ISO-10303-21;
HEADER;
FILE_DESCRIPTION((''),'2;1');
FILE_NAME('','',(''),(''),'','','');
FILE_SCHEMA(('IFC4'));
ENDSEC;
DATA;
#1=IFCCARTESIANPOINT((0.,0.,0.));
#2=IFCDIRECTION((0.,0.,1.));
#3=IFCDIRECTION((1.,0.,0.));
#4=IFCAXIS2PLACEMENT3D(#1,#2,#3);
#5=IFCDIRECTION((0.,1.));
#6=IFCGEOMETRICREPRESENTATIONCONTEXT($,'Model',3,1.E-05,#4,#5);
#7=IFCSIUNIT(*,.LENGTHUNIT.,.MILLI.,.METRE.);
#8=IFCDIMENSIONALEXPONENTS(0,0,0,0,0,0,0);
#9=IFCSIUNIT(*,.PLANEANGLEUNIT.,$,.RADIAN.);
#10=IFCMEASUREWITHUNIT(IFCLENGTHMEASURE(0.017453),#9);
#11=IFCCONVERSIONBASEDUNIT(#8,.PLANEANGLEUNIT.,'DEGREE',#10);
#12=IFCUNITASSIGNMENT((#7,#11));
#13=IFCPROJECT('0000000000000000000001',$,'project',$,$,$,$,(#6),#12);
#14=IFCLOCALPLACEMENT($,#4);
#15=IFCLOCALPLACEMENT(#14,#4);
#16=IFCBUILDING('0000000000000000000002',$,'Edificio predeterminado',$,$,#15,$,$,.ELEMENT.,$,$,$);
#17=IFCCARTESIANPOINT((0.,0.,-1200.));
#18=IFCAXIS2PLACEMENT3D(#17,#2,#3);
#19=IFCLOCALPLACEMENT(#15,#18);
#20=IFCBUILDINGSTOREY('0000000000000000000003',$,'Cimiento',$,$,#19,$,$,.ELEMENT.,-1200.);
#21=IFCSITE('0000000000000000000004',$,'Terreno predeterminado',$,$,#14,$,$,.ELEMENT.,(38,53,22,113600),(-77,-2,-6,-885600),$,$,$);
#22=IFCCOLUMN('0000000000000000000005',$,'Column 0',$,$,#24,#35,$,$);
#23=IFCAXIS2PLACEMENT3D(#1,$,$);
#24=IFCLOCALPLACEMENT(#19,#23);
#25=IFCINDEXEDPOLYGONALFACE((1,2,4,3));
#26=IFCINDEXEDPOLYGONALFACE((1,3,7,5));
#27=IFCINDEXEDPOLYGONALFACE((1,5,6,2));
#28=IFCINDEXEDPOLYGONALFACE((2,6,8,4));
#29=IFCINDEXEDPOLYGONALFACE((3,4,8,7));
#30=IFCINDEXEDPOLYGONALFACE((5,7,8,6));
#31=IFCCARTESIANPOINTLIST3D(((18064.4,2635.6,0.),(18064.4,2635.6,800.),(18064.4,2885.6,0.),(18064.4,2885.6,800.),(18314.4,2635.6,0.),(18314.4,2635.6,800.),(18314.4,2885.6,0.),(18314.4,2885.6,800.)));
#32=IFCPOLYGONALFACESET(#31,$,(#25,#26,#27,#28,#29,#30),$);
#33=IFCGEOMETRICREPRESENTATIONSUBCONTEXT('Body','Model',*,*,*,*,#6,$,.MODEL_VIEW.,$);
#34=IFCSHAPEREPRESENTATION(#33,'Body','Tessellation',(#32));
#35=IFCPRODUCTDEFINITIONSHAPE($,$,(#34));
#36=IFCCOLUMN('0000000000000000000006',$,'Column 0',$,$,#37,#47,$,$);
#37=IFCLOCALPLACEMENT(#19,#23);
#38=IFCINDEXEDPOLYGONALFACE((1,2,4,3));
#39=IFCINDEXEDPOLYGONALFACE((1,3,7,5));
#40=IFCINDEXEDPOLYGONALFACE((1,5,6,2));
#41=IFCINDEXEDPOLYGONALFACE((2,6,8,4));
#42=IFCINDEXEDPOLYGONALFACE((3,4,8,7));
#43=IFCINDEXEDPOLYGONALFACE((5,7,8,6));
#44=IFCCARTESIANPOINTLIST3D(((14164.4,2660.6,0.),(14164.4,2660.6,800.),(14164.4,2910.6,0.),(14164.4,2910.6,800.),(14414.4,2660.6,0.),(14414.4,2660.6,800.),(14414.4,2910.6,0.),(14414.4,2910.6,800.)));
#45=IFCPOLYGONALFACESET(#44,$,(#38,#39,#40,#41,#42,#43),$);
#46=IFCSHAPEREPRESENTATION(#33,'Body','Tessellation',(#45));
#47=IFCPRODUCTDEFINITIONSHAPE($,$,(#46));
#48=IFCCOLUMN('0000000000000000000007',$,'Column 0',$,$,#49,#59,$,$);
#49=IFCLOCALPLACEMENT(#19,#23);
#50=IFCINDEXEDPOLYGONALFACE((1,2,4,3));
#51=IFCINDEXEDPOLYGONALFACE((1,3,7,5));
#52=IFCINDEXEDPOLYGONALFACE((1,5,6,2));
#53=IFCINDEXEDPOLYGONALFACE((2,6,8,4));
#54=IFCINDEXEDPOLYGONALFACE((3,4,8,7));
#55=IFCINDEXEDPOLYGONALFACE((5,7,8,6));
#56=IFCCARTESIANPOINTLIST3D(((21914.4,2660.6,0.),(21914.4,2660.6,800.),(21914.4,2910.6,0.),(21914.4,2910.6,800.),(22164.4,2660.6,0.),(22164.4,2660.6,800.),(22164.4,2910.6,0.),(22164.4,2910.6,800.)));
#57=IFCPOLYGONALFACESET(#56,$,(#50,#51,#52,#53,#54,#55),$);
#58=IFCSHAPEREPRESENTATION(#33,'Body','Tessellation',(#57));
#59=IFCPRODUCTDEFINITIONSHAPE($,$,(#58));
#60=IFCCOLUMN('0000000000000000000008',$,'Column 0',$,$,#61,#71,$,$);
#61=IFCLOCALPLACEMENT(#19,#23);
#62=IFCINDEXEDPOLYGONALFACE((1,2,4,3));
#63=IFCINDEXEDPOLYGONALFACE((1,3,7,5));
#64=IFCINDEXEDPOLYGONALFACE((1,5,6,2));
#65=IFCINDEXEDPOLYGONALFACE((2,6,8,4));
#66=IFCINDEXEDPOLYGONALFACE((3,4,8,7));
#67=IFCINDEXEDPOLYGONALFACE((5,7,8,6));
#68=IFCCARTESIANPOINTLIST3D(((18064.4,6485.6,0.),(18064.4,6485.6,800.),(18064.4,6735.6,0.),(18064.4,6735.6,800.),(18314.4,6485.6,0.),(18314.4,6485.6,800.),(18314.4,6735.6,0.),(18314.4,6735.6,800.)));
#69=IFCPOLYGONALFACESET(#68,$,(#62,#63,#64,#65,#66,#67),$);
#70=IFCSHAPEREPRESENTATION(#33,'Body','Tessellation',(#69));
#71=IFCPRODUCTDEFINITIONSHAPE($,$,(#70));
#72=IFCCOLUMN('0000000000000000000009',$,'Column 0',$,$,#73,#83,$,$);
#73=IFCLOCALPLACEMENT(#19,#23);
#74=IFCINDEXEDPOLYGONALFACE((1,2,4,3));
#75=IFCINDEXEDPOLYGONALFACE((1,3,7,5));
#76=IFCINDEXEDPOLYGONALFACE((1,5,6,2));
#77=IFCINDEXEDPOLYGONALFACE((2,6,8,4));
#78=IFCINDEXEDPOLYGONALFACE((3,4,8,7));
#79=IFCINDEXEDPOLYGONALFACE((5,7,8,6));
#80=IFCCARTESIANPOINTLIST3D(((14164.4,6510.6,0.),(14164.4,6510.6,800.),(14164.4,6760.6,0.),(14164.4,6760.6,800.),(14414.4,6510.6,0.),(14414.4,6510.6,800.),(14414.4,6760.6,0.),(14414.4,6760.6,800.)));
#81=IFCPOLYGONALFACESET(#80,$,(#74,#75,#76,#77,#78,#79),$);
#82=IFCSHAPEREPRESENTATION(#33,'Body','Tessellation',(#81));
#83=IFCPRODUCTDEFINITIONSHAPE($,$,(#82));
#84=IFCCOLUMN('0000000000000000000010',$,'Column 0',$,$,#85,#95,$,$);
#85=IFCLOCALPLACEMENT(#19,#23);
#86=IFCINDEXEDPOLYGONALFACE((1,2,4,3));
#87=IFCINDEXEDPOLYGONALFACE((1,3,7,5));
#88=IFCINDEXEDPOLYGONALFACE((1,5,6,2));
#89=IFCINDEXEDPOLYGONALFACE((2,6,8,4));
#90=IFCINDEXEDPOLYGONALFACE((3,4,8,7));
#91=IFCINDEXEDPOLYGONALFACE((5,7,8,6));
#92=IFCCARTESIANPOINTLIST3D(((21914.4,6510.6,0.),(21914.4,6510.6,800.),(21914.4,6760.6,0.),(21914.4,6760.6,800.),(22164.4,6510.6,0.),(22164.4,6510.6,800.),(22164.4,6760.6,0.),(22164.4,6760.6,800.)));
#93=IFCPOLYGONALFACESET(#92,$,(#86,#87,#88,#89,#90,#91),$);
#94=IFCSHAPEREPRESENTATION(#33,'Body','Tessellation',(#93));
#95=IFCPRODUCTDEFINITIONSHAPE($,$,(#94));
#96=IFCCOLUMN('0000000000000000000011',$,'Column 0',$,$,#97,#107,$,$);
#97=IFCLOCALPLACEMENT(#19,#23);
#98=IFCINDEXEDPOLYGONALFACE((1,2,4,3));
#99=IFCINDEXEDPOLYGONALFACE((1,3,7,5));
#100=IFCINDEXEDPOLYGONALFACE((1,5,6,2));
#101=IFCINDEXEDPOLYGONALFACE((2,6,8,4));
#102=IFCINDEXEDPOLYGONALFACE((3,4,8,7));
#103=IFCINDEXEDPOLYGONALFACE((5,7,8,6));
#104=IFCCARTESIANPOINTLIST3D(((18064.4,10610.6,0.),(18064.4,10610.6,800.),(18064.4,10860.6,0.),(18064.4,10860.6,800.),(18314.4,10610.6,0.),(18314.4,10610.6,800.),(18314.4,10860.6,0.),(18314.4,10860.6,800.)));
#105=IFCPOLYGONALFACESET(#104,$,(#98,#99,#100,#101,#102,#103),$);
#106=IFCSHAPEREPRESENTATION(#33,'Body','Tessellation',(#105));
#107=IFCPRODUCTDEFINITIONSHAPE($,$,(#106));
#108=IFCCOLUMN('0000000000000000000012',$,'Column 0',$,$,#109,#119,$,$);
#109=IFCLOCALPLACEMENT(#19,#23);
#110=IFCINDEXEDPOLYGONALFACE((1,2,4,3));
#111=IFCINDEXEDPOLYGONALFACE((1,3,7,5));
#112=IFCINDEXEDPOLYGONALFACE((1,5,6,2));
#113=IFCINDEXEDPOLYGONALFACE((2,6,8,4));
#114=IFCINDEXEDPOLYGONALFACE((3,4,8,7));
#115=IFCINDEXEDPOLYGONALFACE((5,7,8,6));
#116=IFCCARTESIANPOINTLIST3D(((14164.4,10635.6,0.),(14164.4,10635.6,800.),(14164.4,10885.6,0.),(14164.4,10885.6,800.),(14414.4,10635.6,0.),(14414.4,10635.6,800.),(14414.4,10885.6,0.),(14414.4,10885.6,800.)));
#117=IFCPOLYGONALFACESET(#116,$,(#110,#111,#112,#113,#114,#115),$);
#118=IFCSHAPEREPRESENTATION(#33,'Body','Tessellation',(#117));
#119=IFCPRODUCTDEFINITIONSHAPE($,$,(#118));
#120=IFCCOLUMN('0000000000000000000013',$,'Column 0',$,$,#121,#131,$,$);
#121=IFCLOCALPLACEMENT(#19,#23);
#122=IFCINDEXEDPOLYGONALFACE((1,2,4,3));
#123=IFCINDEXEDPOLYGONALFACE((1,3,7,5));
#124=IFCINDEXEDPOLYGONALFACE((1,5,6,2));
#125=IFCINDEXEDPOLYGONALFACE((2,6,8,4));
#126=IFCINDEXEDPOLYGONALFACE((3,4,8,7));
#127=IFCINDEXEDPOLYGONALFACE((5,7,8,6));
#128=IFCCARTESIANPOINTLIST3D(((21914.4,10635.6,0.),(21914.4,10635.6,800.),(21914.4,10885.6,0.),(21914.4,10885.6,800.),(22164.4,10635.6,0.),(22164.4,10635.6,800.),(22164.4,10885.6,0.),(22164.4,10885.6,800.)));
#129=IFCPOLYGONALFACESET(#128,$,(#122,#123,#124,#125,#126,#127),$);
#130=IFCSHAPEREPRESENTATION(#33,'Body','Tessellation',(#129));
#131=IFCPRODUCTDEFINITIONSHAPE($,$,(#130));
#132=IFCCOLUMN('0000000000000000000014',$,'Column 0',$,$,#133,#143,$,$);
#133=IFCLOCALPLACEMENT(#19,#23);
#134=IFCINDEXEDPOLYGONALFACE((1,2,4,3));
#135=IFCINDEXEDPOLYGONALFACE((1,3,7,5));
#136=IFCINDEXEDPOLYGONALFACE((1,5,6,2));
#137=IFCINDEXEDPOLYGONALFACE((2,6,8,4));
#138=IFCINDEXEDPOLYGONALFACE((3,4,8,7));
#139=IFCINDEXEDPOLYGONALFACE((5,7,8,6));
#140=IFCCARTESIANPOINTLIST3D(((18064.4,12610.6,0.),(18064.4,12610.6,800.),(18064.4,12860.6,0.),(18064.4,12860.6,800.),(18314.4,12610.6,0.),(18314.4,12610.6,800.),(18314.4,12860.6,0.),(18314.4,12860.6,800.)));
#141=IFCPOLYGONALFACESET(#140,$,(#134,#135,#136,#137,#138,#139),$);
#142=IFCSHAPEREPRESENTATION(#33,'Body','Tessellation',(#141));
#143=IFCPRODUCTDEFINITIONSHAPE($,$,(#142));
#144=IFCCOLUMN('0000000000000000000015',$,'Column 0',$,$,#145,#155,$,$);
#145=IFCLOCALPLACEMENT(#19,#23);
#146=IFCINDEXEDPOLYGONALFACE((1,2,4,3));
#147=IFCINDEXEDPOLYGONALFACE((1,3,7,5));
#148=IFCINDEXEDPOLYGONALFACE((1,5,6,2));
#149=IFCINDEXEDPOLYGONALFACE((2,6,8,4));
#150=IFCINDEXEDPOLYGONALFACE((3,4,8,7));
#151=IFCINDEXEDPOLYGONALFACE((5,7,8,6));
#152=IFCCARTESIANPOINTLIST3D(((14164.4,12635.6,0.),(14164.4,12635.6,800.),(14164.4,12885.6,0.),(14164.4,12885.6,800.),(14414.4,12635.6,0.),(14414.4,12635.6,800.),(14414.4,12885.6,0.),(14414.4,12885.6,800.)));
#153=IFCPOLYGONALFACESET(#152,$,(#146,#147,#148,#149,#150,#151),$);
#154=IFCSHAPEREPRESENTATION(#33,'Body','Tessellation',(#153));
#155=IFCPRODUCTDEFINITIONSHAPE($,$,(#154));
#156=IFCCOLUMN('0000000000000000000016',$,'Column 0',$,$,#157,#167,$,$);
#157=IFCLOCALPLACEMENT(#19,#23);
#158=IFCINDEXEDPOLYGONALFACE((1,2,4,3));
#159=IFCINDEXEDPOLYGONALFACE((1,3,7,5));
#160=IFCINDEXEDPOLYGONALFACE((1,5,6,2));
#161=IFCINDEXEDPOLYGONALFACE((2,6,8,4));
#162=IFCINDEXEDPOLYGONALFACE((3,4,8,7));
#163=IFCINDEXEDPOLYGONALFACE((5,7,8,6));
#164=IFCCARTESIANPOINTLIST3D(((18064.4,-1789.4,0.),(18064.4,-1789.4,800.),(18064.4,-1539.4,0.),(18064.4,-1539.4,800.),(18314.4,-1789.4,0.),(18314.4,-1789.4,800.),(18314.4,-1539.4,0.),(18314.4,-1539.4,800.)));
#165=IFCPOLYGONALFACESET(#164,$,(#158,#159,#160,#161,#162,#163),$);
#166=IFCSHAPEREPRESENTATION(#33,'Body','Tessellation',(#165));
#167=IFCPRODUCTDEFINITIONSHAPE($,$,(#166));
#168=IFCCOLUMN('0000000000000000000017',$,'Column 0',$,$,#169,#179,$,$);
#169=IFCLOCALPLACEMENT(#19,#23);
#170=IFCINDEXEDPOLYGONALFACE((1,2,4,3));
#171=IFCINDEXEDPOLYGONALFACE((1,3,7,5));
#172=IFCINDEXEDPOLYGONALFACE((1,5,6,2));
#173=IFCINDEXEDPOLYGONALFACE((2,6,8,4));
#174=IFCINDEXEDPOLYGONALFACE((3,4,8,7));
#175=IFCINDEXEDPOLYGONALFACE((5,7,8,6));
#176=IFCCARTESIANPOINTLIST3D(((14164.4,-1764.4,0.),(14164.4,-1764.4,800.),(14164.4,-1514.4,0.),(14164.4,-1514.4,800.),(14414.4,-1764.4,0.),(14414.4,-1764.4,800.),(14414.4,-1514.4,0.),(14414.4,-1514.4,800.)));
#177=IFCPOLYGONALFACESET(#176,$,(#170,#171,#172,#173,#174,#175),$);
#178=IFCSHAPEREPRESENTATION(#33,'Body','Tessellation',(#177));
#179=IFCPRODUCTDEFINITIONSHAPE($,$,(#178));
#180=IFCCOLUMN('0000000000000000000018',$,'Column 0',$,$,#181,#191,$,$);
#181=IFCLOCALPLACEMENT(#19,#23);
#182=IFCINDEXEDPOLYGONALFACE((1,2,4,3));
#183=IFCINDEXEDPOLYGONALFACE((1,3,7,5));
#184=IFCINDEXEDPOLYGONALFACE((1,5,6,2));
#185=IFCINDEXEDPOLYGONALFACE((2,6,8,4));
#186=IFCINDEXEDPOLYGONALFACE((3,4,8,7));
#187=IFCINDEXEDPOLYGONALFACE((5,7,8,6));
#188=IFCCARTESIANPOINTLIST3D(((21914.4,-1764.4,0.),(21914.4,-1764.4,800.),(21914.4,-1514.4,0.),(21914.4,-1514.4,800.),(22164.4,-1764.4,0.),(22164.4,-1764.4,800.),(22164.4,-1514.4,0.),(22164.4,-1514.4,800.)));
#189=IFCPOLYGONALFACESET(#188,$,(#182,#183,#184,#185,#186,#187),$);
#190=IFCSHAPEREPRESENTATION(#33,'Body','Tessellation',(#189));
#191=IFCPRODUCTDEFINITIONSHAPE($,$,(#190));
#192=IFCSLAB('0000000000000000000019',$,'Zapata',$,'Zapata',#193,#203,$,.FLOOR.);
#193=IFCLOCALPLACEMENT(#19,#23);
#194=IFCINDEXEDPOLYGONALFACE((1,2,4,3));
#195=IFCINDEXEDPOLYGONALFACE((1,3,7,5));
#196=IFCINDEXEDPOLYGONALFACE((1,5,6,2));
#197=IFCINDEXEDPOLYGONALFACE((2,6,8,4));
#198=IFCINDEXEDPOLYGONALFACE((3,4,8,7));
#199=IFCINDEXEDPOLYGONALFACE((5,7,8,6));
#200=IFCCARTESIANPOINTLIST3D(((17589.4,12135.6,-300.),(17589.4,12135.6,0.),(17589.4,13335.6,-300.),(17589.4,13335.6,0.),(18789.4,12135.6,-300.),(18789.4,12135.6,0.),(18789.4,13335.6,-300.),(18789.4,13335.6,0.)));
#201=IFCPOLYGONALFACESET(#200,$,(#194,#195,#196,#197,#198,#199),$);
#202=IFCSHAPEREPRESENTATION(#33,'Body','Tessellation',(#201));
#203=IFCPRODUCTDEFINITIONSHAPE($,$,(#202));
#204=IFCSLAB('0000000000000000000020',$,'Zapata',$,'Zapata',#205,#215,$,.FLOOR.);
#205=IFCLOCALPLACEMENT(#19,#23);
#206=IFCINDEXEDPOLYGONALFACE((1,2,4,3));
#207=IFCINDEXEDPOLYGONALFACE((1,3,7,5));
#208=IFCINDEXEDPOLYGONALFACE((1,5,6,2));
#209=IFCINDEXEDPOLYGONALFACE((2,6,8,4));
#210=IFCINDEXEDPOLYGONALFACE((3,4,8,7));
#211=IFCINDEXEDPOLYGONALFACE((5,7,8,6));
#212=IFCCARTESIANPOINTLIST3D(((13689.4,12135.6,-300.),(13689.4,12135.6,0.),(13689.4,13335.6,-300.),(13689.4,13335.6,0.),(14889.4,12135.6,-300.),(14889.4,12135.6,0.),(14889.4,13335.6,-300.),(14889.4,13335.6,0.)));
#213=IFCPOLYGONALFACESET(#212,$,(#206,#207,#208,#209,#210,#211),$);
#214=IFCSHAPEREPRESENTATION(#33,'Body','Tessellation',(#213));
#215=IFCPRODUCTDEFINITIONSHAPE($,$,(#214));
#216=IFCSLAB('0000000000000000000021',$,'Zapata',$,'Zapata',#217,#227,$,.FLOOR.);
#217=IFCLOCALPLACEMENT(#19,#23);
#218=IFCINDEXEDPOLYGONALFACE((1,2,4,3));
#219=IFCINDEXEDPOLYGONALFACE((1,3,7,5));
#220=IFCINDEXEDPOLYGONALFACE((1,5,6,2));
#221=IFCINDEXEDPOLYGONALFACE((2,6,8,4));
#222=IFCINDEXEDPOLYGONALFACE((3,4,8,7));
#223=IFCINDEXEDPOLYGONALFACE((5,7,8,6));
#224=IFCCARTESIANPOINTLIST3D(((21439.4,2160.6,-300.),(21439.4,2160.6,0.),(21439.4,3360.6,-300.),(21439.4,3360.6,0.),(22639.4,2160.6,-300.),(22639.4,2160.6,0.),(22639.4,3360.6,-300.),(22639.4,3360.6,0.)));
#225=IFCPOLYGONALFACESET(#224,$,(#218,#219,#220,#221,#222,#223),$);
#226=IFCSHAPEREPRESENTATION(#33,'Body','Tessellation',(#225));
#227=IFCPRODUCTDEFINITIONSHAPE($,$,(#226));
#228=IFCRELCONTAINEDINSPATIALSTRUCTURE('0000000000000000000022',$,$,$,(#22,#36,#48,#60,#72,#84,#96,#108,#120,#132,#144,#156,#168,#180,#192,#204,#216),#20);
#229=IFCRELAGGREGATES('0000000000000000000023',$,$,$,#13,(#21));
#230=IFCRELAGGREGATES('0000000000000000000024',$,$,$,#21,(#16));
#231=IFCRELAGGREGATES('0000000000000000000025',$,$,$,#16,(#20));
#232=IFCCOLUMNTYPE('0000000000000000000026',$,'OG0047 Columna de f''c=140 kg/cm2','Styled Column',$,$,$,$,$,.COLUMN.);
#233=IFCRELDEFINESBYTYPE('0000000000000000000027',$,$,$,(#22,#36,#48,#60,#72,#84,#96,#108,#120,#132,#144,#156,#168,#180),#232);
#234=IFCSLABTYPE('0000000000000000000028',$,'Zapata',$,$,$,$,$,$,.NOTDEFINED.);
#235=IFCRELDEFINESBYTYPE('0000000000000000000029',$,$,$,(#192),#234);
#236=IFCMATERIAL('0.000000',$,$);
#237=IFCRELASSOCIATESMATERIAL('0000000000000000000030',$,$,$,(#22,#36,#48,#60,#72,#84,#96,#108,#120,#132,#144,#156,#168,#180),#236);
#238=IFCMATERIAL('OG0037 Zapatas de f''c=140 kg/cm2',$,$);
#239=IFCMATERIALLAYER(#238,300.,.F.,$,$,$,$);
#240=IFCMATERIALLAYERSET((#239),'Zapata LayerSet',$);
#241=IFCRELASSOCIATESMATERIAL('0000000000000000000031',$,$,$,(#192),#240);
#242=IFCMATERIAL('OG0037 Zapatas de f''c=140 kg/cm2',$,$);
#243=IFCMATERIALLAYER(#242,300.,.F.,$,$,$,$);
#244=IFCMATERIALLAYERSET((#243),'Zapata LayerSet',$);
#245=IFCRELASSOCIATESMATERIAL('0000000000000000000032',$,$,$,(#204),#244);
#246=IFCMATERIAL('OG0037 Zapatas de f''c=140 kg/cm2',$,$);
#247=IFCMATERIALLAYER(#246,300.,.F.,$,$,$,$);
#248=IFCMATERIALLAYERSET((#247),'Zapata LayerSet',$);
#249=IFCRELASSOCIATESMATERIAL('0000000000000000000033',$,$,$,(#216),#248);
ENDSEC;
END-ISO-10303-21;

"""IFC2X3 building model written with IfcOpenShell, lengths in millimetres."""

from ifc_helpers import new_model, entity, si_unit, converted_unit, direction, frame, origin_with_axes, place, context, subcontext, project, spatial, polyline, outline, extrude, material, layer, layer_set, layer_usage, type_object, element, save


model = new_model("IFC2X3")

# Units and contexts
model_context = context("Model", 3, precision=1e-05, world=origin_with_axes(), true_north=direction((0.0, 1.0)))
body_context = subcontext(model_context, "Body", "Model", "MODEL_VIEW")
ifc_project = project(units=[si_unit("LENGTHUNIT", "METRE", prefix="MILLI"), converted_unit("PLANEANGLEUNIT", "DEGREE", entity("IfcLengthMeasure", 0.017453), si_unit("PLANEANGLEUNIT", "RADIAN"), dimensions=[0, 0, 0, 0, 0, 0, 0])], contexts=[model_context])

# Site, building, storey
site_placement = place(None, origin_with_axes())
site = spatial("IfcSite", under=ifc_project, at=site_placement, Name="Terreno predeterminado", CompositionType="ELEMENT", RefLatitude=(38, 53, 22, 113600), RefLongitude=(-77, -2, -6, -885600))
building_placement = place(site_placement, origin_with_axes())
building = spatial("IfcBuilding", under=site, at=building_placement, Name="Edificio predeterminado", CompositionType="ELEMENT")
storey_placement = place(building_placement, frame((0.0, 0.0, -1200.0), z_axis=(0.0, 0.0, 1.0), x_axis=(1.0, 0.0, 0.0)))
storey = spatial("IfcBuildingStorey", under=building, at=storey_placement, Name="Cimiento", CompositionType="ELEMENT", Elevation=-1200.0)

# Columns
ifc_material_1 = material(Name="0.000000")
column_type = type_object("IfcColumnType", Name="OG0047 Columna de f'c=140 kg/cm2", Description="Styled Column", PredefinedType="COLUMN")
for number, where, z_axis, x_axis, name in (
    (1, (18189.4, 2760.6, 0.0), (0.0, 0.0, 1.0), (1.0, 0.0, 0.0), "Column 0"),
    (2, (14289.4, 2785.6, 0.0), (0.0, 0.0, 1.0), (1.0, 0.0, 0.0), "Column 0"),
    (3, (22039.4, 2785.6, 0.0), (0.0, 0.0, 1.0), (1.0, 0.0, 0.0), "Column 0"),
    (4, (18189.4, 6610.6, 0.0), (0.0, 0.0, 1.0), (1.0, 0.0, 0.0), "Column 0"),
    (5, (14289.4, 6635.6, 0.0), (0.0, 0.0, 1.0), (1.0, 0.0, 0.0), "Column 0"),
    (6, (22039.4, 6635.6, 0.0), (0.0, 0.0, 1.0), (1.0, 0.0, 0.0), "Column 0"),
    (7, (18189.4, 10735.6, 0.0), (0.0, 0.0, 1.0), (1.0, 0.0, 0.0), "Column 0"),
    (8, (14289.4, 10760.6, 0.0), (0.0, 0.0, 1.0), (1.0, 0.0, 0.0), "Column 0"),
    (9, (22039.4, 10760.6, 0.0), (0.0, 0.0, 1.0), (1.0, 0.0, 0.0), "Column 0"),
    (10, (18189.4, 12735.6, 0.0), (0.0, 0.0, 1.0), (1.0, 0.0, 0.0), "Column 0"),
    (11, (14289.4, 12760.6, 0.0), (0.0, 0.0, 1.0), (1.0, 0.0, 0.0), "Column 0"),
    (12, (18189.4, -1664.4, 0.0), (0.0, 0.0, 1.0), (1.0, 0.0, 0.0), "Column 0"),
    (13, (14289.4, -1639.4, 0.0), (0.0, 0.0, 1.0), (1.0, 0.0, 0.0), "Column 0"),
    (14, (22039.4, -1639.4, 0.0), (0.0, 0.0, 1.0), (1.0, 0.0, 0.0), "Column 0"),
):
    element("IfcColumn", number, at=place(storey_placement, frame(where, z_axis=z_axis, x_axis=x_axis)), inside=storey, type_object=column_type, material=ifc_material_1, Name=name, context=body_context, shape_type="SweptSolid", body=[
        extrude(outline(polyline([(-125.0, -125.0), (125.0, -125.0), (125.0, 125.0), (-125.0, 125.0), (-125.0, -125.0)])), origin_with_axes(), (0.0, 0.0, 1.0), 800.0),
    ])

# Slabs
ifc_material_2 = material(Name="OG0037 Zapatas de f'c=140 kg/cm2")
ifc_layer_1 = layer(ifc_material_2, 300.0, ventilated=False)
ifc_layer_set_1 = layer_set([ifc_layer_1], Name="Zapata LayerSet")
ifc_layer_usage_1 = layer_usage(ifc_layer_set_1, "AXIS3", "POSITIVE", 0.0)
slab_type = type_object("IfcSlabType", Name="Zapata")
slab_1_placement = place(storey_placement, frame((0.0, 0.0, 1200.0), z_axis=(0.0, 0.0, 1.0), x_axis=(1.0, 0.0, 0.0)))
element("IfcSlab", 15, at=slab_1_placement, inside=storey, type_object=slab_type, material=ifc_layer_usage_1, Name="Zapata", ObjectType="Zapata", PredefinedType="FLOOR", context=body_context, shape_type="SweptSolid", body=[
    extrude(outline(polyline([(0.0, 0.0), (1200.0, 0.0), (1200.0, 1200.0), (0.0, 1200.0), (0.0, 0.0)])), frame((17589.4, 13335.6, -1500.0), z_axis=(0.0, 0.0, -1.0), x_axis=(1.0, 0.0, 0.0)), (0.0, 0.0, -1.0), 300.0),
])
ifc_material_3 = material(Name="OG0037 Zapatas de f'c=140 kg/cm2")
ifc_layer_2 = layer(ifc_material_3, 300.0, ventilated=False)
ifc_layer_set_2 = layer_set([ifc_layer_2], Name="Zapata LayerSet")
ifc_layer_usage_2 = layer_usage(ifc_layer_set_2, "AXIS3", "POSITIVE", 0.0)
slab_2_placement = place(storey_placement, frame((0.0, 0.0, 1200.0), z_axis=(0.0, 0.0, 1.0), x_axis=(1.0, 0.0, 0.0)))
element("IfcSlab", 16, at=slab_2_placement, inside=storey, material=ifc_layer_usage_2, Name="Zapata", ObjectType="Zapata", PredefinedType="FLOOR", context=body_context, shape_type="SweptSolid", body=[
    extrude(outline(polyline([(0.0, 0.0), (1200.0, 0.0), (1200.0, 1200.0), (0.0, 1200.0), (0.0, 0.0)])), frame((13689.4, 13335.6, -1500.0), z_axis=(0.0, 0.0, -1.0), x_axis=(1.0, 0.0, 0.0)), (0.0, 0.0, -1.0), 300.0),
])
ifc_material_4 = material(Name="OG0037 Zapatas de f'c=140 kg/cm2")
ifc_layer_3 = layer(ifc_material_4, 300.0, ventilated=False)
ifc_layer_set_3 = layer_set([ifc_layer_3], Name="Zapata LayerSet")
ifc_layer_usage_3 = layer_usage(ifc_layer_set_3, "AXIS3", "POSITIVE", 0.0)
slab_3_placement = place(storey_placement, frame((0.0, 0.0, 1200.0), z_axis=(0.0, 0.0, 1.0), x_axis=(1.0, 0.0, 0.0)))
element("IfcSlab", 17, at=slab_3_placement, inside=storey, material=ifc_layer_usage_3, Name="Zapata", ObjectType="Zapata", PredefinedType="FLOOR", context=body_context, shape_type="SweptSolid", body=[
    extrude(outline(polyline([(0.0, 0.0), (1200.0, 0.0), (1200.0, 1200.0), (0.0, 1200.0), (0.0, 0.0)])), frame((21439.4, 3360.6, -1500.0), z_axis=(0.0, 0.0, -1.0), x_axis=(1.0, 0.0, 0.0)), (0.0, 0.0, -1.0), 300.0),
])

save(model, "model.ifc")
